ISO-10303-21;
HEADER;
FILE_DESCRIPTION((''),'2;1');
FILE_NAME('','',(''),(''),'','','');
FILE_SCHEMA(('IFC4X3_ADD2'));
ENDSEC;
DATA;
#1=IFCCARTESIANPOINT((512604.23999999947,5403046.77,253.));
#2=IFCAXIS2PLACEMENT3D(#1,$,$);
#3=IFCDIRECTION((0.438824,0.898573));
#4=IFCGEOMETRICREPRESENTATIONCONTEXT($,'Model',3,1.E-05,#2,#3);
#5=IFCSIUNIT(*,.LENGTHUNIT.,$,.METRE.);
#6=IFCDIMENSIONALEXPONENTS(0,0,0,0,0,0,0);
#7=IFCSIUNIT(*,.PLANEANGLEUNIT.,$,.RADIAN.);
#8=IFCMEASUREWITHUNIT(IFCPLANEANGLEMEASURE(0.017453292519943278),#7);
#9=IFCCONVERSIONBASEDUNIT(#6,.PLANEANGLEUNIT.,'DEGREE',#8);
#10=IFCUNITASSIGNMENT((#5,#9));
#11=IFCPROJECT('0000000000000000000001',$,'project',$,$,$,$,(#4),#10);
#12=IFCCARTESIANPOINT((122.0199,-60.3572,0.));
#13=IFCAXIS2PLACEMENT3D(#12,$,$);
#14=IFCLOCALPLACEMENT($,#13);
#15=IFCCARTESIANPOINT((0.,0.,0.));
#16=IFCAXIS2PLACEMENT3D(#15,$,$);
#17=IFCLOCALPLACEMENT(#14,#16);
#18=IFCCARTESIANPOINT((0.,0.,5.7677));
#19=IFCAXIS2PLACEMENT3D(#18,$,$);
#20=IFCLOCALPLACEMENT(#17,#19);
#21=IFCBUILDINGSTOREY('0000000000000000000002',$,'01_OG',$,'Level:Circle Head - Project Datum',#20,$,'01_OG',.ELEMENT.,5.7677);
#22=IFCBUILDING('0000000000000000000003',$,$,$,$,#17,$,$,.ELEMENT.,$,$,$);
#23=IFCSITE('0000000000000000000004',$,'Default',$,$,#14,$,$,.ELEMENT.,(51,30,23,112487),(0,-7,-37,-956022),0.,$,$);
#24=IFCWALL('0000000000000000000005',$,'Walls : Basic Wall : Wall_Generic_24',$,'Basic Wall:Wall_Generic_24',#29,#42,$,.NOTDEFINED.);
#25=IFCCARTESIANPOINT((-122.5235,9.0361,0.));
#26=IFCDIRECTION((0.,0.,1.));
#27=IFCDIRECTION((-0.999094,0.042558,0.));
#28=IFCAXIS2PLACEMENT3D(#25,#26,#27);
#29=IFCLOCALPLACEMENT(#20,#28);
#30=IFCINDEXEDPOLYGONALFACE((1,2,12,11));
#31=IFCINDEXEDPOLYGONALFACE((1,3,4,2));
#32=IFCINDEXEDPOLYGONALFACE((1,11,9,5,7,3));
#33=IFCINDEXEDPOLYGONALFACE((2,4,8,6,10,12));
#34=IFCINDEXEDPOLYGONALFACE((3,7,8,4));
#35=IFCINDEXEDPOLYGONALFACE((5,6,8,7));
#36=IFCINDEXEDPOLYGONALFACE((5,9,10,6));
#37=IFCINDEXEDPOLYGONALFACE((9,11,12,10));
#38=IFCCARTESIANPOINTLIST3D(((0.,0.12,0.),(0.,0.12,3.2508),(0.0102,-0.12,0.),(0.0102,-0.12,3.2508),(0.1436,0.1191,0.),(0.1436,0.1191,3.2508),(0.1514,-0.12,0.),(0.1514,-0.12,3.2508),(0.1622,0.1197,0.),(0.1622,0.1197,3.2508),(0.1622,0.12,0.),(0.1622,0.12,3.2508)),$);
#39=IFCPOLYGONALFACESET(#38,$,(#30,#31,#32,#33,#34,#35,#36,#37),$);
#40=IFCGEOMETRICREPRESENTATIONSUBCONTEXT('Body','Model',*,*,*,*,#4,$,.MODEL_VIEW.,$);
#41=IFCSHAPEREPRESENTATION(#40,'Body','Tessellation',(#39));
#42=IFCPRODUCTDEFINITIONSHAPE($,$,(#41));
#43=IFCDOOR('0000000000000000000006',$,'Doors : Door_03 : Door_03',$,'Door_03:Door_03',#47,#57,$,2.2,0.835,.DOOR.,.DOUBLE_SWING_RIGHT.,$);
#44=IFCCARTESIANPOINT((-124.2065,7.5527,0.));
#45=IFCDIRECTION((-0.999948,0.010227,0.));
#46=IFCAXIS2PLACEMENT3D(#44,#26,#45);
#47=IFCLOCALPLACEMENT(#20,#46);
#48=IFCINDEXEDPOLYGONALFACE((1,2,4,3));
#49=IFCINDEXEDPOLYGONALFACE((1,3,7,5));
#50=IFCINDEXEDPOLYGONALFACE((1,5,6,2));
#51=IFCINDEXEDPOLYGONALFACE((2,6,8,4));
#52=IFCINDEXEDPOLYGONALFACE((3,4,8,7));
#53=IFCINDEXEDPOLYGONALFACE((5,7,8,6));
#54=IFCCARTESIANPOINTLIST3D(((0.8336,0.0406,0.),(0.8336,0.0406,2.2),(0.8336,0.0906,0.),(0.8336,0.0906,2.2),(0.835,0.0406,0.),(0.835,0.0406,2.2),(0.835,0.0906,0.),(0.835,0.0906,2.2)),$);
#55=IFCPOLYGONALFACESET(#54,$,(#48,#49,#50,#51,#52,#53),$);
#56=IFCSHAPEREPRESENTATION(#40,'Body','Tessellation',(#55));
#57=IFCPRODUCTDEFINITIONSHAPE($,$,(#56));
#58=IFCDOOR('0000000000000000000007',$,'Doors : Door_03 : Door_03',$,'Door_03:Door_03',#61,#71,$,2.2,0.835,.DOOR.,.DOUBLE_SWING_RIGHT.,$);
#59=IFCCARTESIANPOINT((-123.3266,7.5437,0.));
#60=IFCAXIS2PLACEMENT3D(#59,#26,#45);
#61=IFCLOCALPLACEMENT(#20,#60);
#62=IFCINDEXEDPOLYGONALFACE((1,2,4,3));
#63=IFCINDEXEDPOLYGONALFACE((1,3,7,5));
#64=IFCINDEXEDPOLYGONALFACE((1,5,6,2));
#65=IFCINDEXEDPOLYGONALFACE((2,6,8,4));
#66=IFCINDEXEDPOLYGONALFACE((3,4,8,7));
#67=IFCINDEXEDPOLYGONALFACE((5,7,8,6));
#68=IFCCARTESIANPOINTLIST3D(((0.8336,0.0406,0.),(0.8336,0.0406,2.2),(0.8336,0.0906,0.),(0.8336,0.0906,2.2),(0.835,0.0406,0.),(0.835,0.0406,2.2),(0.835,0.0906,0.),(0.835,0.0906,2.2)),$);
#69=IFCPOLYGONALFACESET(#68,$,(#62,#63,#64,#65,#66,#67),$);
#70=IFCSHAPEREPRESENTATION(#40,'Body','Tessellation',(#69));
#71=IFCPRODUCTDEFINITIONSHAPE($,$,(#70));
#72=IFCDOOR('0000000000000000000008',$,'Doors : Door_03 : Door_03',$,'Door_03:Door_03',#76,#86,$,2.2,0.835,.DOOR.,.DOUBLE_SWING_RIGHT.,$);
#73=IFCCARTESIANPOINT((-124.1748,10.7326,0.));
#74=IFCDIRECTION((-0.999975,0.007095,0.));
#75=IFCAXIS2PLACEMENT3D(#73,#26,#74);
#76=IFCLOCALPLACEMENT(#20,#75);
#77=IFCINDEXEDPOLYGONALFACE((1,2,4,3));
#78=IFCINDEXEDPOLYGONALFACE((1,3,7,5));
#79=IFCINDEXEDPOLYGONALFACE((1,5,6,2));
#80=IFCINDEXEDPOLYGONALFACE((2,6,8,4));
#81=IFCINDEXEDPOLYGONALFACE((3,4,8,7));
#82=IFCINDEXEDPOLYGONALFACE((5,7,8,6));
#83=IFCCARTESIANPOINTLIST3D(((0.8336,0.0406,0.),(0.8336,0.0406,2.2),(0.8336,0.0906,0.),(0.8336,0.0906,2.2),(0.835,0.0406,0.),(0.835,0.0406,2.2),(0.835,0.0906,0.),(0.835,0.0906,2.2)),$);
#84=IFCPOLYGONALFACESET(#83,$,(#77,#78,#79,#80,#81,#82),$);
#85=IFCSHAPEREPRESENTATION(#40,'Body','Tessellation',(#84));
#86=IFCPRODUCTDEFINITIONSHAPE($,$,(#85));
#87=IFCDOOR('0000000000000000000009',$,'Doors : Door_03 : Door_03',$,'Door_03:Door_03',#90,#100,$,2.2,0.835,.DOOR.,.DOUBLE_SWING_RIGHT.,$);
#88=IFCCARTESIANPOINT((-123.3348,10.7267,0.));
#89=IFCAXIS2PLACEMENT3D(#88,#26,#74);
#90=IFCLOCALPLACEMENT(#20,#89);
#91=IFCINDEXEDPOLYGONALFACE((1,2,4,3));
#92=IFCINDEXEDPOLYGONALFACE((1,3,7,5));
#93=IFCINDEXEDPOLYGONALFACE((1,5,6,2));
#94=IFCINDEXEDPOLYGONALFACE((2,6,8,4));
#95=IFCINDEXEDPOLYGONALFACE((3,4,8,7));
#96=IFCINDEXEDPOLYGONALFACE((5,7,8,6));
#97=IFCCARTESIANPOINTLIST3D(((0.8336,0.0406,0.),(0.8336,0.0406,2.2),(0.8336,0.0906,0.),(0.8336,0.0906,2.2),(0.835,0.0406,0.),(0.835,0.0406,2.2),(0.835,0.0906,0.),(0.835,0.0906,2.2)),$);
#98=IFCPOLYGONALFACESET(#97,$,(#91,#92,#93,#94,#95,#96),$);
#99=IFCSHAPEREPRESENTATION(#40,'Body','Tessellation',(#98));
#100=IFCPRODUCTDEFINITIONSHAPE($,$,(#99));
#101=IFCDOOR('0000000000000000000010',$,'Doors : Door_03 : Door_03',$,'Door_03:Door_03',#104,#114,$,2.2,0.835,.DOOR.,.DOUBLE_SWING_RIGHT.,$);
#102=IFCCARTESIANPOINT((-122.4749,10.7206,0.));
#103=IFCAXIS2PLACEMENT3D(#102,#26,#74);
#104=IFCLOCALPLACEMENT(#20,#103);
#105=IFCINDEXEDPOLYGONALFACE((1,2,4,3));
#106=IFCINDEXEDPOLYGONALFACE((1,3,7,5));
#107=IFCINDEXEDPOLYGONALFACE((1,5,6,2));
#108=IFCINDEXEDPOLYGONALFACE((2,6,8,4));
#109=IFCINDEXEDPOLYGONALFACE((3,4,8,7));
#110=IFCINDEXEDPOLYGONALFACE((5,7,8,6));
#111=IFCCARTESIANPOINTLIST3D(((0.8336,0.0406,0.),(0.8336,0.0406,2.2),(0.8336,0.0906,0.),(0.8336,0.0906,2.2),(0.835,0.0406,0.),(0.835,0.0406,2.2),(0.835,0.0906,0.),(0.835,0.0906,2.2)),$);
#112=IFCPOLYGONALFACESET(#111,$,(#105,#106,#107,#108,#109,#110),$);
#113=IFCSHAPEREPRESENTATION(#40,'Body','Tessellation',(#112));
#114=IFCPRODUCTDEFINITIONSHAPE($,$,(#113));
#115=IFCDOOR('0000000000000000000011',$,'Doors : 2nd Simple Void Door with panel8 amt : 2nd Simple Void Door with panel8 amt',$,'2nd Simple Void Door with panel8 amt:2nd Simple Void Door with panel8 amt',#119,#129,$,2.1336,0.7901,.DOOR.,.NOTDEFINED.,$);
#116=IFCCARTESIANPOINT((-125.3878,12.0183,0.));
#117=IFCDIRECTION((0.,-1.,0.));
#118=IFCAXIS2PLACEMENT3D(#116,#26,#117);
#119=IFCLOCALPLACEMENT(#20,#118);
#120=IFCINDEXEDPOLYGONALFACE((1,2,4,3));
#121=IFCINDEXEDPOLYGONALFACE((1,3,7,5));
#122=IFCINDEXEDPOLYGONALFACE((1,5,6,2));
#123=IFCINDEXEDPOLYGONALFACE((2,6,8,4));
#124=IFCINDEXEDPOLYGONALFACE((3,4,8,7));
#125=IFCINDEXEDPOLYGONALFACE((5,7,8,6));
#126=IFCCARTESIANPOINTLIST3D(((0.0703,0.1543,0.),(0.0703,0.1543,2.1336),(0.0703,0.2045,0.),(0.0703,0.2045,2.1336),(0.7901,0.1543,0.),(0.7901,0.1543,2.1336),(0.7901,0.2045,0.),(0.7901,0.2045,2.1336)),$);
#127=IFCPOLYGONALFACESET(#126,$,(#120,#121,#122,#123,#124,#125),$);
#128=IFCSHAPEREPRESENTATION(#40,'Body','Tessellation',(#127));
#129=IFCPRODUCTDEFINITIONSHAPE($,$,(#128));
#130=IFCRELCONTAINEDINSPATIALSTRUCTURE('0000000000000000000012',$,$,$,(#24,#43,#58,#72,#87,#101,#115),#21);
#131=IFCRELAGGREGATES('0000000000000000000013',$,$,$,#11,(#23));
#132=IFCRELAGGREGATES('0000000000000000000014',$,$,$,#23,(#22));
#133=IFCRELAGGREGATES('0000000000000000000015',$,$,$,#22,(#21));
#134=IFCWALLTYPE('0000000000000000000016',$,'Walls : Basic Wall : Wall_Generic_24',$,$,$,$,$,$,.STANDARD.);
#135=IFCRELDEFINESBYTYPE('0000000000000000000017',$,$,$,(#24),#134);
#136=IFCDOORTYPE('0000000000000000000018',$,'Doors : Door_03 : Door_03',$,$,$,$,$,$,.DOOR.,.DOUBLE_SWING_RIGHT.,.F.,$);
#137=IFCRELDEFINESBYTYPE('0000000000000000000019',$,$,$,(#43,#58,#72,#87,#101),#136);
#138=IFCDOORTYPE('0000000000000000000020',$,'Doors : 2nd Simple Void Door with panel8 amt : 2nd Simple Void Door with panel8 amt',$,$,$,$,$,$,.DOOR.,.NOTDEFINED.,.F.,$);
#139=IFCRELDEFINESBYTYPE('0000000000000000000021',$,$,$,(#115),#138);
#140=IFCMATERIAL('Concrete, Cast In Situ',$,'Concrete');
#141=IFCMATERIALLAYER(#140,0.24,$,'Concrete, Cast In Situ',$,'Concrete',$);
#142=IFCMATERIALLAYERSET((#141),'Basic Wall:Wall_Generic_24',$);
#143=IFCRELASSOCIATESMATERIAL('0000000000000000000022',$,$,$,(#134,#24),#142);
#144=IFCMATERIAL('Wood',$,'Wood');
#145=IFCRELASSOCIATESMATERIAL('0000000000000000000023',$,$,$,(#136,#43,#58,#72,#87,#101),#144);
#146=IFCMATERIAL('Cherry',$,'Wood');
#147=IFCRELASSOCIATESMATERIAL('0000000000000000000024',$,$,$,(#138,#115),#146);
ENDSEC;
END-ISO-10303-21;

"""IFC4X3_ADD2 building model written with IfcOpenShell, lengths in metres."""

from ifc_helpers import new_model, entity, si_unit, converted_unit, direction, frame, origin, origin_2d_with_axis, place, context, subcontext, project, spatial, polyline, rectangle, outline, extrude, clip, bounded_halfspace, source, transform, mapped, material, layer, layer_set, type_object, type_shapes, element, save


model = new_model("IFC4X3_ADD2")

# Units and contexts
model_context = context("Model", 3, precision=1e-05, world=frame((512604.23999999947, 5403046.77, 253.0)), true_north=direction((0.438824, 0.898573)))
body_context = subcontext(model_context, "Body", "Model", "MODEL_VIEW")
ifc_project = project(units=[si_unit("LENGTHUNIT", "METRE"), converted_unit("PLANEANGLEUNIT", "DEGREE", entity("IfcPlaneAngleMeasure", 0.017453292519943278), si_unit("PLANEANGLEUNIT", "RADIAN"), dimensions=[0, 0, 0, 0, 0, 0, 0])], contexts=[model_context])

# Site, building, storey
site_placement = place(None, frame((122.0199, -60.3572, 0.0)))
site = spatial("IfcSite", under=ifc_project, at=site_placement, Name="Default", CompositionType="ELEMENT", RefLatitude=(51, 30, 23, 112487), RefLongitude=(0, -7, -37, -956022), RefElevation=0.0)
building_placement = place(site_placement, origin())
building = spatial("IfcBuilding", under=site, at=building_placement, CompositionType="ELEMENT")
storey_placement = place(building_placement, frame((0.0, 0.0, 5.7677)))
storey = spatial("IfcBuildingStorey", under=building, at=storey_placement, Name="01_OG", ObjectType="Level:Circle Head - Project Datum", LongName="01_OG", CompositionType="ELEMENT", Elevation=5.7677)

# Wall
ifc_material_1 = material(Name="Concrete, Cast In Situ", Category="Concrete")
ifc_layer_1 = layer(ifc_material_1, 0.24, Name="Concrete, Cast In Situ", Category="Concrete")
ifc_layer_set_1 = layer_set([ifc_layer_1], Name="Basic Wall:Wall_Generic_24")
wall_type_1 = type_object("IfcWallType", Name="Walls : Basic Wall : Wall_Generic_24", PredefinedType="STANDARD", material=ifc_layer_set_1)
wall_1_placement = place(storey_placement, frame((-122.5235, 9.0361, 0.0), z_axis=(0.0, 0.0, 1.0), x_axis=(-0.999094, 0.042558, 0.0)))
element("IfcWall", 1, at=wall_1_placement, inside=storey, type_object=wall_type_1, material=ifc_layer_set_1, Name="Walls : Basic Wall : Wall_Generic_24", ObjectType="Basic Wall:Wall_Generic_24", PredefinedType="NOTDEFINED", context=body_context, shape_type="Clipping", body=[
    clip(clip(clip(extrude(outline(polyline([(0.0, 0.12), (0.0102, -0.12), (0.1514, -0.12), (0.1436, 0.1191), (0.1622, 0.1197), (0.1622, 0.12), (0.0, 0.12)])), origin(), (0.0, 0.0, 1.0), 3.2508), bounded_halfspace(frame((0.1622, 0.12, 3.2508), z_axis=(0.0, 0.0, -1.0), x_axis=(-0.036139, 0.999347, 0.0)), True, frame((0.1622, 0.12, 3.2508)), polyline([(0.0, 0.0), (-0.1622, 0.0), (-0.152, -0.24), (-0.0108, -0.24), (-0.0186, -0.0009), (0.0, 0.0)]))), bounded_halfspace(frame((0.1436, 0.1191, 3.2508), z_axis=(-0.032855, 0.99946, 0.0), x_axis=(-0.99946, -0.032855, 0.0)), True, frame((0.1436, 0.1191, 3.2508), z_axis=(-0.032855, 0.99946, 0.0), x_axis=(-0.99946, -0.032855, 0.0)), polyline([(0.0, 0.0), (-0.0186, 0.0), (-0.0186, -3.2508), (0.0, -3.2508), (0.0, 0.0)]))), bounded_halfspace(frame((0.1436, 0.1191, 0.0), z_axis=(-0.99946, -0.032855, 0.0), x_axis=(0.032855, -0.99946, 0.0)), True, frame((0.1436, 0.1191, 0.0), z_axis=(-0.99946, -0.032855, 0.0), x_axis=(0.032855, -0.99946, 0.0)), polyline([(0.0, 0.0), (0.2393, 0.0), (0.2393, 3.2508), (0.0, 3.2508), (0.0, 0.0)]))),
])

# Shared definitions
ifc_material_2 = material(Name="Wood", Category="Wood")

# Doors
door_type_1 = type_object("IfcDoorType", Name="Doors : Door_03 : Door_03", OperationType="DOUBLE_SWING_RIGHT", ParameterTakesPrecedence=False, PredefinedType="DOOR", material=ifc_material_2)
shared_shape_1 = source(origin(), body_context, "Body", "SweptSolid", [
    extrude(rectangle(XDim=0.0014, YDim=0.05, at=origin_2d_with_axis()), frame((0.8343, 0.0656, 0.0), z_axis=(0.0, 0.0, 1.0), x_axis=(-1.0, 0.0, 0.0)), (0.0, 0.0, 1.0), 2.2),
])
type_shapes(door_type_1, [shared_shape_1])
for number, where, z_axis, x_axis, name in (
    (2, (-124.2065, 7.5527, 0.0), (0.0, 0.0, 1.0), (-0.999948, 0.010227, 0.0), "Doors : Door_03 : Door_03"),
    (3, (-123.3266, 7.5437, 0.0), (0.0, 0.0, 1.0), (-0.999948, 0.010227, 0.0), "Doors : Door_03 : Door_03"),
    (4, (-124.1748, 10.7326, 0.0), (0.0, 0.0, 1.0), (-0.999975, 0.007095, 0.0), "Doors : Door_03 : Door_03"),
    (5, (-123.3348, 10.7267, 0.0), (0.0, 0.0, 1.0), (-0.999975, 0.007095, 0.0), "Doors : Door_03 : Door_03"),
    (6, (-122.4749, 10.7206, 0.0), (0.0, 0.0, 1.0), (-0.999975, 0.007095, 0.0), "Doors : Door_03 : Door_03"),
):
    element("IfcDoor", number, at=place(storey_placement, frame(where, z_axis=z_axis, x_axis=x_axis)), inside=storey, type_object=door_type_1, material=ifc_material_2, Name=name, ObjectType="Door_03:Door_03", OperationType="DOUBLE_SWING_RIGHT", OverallHeight=2.2, OverallWidth=0.835, PredefinedType="DOOR", context=body_context, shape_type="MappedRepresentation", body=[
        mapped(shared_shape_1, transform((0.0, 0.0, 0.0), scale=1.0)),
    ])
ifc_material_3 = material(Name="Cherry", Category="Wood")
door_type_2 = type_object("IfcDoorType", Name="Doors : 2nd Simple Void Door with panel8 amt : 2nd Simple Void Door with panel8 amt", OperationType="NOTDEFINED", ParameterTakesPrecedence=False, PredefinedType="DOOR", material=ifc_material_3)
shared_shape_2 = source(origin(), body_context, "Body", "SweptSolid", [
    extrude(rectangle(XDim=0.7198, YDim=0.0501, at=origin_2d_with_axis()), frame((0.4302, 0.1794, 0.0)), (0.0, 0.0, 1.0), 2.1336),
])
type_shapes(door_type_2, [shared_shape_2])
door_1_placement = place(storey_placement, frame((-125.3878, 12.0183, 0.0), z_axis=(0.0, 0.0, 1.0), x_axis=(0.0, -1.0, 0.0)))
element("IfcDoor", 7, at=door_1_placement, inside=storey, type_object=door_type_2, material=ifc_material_3, Name="Doors : 2nd Simple Void Door with panel8 amt : 2nd Simple Void Door with panel8 amt", ObjectType="2nd Simple Void Door with panel8 amt:2nd Simple Void Door with panel8 amt", OperationType="NOTDEFINED", OverallHeight=2.1336, OverallWidth=0.7901, PredefinedType="DOOR", context=body_context, shape_type="MappedRepresentation", body=[
    mapped(shared_shape_2, transform((0.0, 0.0, 0.0), scale=1.0)),
])

save(model, "model.ifc")
